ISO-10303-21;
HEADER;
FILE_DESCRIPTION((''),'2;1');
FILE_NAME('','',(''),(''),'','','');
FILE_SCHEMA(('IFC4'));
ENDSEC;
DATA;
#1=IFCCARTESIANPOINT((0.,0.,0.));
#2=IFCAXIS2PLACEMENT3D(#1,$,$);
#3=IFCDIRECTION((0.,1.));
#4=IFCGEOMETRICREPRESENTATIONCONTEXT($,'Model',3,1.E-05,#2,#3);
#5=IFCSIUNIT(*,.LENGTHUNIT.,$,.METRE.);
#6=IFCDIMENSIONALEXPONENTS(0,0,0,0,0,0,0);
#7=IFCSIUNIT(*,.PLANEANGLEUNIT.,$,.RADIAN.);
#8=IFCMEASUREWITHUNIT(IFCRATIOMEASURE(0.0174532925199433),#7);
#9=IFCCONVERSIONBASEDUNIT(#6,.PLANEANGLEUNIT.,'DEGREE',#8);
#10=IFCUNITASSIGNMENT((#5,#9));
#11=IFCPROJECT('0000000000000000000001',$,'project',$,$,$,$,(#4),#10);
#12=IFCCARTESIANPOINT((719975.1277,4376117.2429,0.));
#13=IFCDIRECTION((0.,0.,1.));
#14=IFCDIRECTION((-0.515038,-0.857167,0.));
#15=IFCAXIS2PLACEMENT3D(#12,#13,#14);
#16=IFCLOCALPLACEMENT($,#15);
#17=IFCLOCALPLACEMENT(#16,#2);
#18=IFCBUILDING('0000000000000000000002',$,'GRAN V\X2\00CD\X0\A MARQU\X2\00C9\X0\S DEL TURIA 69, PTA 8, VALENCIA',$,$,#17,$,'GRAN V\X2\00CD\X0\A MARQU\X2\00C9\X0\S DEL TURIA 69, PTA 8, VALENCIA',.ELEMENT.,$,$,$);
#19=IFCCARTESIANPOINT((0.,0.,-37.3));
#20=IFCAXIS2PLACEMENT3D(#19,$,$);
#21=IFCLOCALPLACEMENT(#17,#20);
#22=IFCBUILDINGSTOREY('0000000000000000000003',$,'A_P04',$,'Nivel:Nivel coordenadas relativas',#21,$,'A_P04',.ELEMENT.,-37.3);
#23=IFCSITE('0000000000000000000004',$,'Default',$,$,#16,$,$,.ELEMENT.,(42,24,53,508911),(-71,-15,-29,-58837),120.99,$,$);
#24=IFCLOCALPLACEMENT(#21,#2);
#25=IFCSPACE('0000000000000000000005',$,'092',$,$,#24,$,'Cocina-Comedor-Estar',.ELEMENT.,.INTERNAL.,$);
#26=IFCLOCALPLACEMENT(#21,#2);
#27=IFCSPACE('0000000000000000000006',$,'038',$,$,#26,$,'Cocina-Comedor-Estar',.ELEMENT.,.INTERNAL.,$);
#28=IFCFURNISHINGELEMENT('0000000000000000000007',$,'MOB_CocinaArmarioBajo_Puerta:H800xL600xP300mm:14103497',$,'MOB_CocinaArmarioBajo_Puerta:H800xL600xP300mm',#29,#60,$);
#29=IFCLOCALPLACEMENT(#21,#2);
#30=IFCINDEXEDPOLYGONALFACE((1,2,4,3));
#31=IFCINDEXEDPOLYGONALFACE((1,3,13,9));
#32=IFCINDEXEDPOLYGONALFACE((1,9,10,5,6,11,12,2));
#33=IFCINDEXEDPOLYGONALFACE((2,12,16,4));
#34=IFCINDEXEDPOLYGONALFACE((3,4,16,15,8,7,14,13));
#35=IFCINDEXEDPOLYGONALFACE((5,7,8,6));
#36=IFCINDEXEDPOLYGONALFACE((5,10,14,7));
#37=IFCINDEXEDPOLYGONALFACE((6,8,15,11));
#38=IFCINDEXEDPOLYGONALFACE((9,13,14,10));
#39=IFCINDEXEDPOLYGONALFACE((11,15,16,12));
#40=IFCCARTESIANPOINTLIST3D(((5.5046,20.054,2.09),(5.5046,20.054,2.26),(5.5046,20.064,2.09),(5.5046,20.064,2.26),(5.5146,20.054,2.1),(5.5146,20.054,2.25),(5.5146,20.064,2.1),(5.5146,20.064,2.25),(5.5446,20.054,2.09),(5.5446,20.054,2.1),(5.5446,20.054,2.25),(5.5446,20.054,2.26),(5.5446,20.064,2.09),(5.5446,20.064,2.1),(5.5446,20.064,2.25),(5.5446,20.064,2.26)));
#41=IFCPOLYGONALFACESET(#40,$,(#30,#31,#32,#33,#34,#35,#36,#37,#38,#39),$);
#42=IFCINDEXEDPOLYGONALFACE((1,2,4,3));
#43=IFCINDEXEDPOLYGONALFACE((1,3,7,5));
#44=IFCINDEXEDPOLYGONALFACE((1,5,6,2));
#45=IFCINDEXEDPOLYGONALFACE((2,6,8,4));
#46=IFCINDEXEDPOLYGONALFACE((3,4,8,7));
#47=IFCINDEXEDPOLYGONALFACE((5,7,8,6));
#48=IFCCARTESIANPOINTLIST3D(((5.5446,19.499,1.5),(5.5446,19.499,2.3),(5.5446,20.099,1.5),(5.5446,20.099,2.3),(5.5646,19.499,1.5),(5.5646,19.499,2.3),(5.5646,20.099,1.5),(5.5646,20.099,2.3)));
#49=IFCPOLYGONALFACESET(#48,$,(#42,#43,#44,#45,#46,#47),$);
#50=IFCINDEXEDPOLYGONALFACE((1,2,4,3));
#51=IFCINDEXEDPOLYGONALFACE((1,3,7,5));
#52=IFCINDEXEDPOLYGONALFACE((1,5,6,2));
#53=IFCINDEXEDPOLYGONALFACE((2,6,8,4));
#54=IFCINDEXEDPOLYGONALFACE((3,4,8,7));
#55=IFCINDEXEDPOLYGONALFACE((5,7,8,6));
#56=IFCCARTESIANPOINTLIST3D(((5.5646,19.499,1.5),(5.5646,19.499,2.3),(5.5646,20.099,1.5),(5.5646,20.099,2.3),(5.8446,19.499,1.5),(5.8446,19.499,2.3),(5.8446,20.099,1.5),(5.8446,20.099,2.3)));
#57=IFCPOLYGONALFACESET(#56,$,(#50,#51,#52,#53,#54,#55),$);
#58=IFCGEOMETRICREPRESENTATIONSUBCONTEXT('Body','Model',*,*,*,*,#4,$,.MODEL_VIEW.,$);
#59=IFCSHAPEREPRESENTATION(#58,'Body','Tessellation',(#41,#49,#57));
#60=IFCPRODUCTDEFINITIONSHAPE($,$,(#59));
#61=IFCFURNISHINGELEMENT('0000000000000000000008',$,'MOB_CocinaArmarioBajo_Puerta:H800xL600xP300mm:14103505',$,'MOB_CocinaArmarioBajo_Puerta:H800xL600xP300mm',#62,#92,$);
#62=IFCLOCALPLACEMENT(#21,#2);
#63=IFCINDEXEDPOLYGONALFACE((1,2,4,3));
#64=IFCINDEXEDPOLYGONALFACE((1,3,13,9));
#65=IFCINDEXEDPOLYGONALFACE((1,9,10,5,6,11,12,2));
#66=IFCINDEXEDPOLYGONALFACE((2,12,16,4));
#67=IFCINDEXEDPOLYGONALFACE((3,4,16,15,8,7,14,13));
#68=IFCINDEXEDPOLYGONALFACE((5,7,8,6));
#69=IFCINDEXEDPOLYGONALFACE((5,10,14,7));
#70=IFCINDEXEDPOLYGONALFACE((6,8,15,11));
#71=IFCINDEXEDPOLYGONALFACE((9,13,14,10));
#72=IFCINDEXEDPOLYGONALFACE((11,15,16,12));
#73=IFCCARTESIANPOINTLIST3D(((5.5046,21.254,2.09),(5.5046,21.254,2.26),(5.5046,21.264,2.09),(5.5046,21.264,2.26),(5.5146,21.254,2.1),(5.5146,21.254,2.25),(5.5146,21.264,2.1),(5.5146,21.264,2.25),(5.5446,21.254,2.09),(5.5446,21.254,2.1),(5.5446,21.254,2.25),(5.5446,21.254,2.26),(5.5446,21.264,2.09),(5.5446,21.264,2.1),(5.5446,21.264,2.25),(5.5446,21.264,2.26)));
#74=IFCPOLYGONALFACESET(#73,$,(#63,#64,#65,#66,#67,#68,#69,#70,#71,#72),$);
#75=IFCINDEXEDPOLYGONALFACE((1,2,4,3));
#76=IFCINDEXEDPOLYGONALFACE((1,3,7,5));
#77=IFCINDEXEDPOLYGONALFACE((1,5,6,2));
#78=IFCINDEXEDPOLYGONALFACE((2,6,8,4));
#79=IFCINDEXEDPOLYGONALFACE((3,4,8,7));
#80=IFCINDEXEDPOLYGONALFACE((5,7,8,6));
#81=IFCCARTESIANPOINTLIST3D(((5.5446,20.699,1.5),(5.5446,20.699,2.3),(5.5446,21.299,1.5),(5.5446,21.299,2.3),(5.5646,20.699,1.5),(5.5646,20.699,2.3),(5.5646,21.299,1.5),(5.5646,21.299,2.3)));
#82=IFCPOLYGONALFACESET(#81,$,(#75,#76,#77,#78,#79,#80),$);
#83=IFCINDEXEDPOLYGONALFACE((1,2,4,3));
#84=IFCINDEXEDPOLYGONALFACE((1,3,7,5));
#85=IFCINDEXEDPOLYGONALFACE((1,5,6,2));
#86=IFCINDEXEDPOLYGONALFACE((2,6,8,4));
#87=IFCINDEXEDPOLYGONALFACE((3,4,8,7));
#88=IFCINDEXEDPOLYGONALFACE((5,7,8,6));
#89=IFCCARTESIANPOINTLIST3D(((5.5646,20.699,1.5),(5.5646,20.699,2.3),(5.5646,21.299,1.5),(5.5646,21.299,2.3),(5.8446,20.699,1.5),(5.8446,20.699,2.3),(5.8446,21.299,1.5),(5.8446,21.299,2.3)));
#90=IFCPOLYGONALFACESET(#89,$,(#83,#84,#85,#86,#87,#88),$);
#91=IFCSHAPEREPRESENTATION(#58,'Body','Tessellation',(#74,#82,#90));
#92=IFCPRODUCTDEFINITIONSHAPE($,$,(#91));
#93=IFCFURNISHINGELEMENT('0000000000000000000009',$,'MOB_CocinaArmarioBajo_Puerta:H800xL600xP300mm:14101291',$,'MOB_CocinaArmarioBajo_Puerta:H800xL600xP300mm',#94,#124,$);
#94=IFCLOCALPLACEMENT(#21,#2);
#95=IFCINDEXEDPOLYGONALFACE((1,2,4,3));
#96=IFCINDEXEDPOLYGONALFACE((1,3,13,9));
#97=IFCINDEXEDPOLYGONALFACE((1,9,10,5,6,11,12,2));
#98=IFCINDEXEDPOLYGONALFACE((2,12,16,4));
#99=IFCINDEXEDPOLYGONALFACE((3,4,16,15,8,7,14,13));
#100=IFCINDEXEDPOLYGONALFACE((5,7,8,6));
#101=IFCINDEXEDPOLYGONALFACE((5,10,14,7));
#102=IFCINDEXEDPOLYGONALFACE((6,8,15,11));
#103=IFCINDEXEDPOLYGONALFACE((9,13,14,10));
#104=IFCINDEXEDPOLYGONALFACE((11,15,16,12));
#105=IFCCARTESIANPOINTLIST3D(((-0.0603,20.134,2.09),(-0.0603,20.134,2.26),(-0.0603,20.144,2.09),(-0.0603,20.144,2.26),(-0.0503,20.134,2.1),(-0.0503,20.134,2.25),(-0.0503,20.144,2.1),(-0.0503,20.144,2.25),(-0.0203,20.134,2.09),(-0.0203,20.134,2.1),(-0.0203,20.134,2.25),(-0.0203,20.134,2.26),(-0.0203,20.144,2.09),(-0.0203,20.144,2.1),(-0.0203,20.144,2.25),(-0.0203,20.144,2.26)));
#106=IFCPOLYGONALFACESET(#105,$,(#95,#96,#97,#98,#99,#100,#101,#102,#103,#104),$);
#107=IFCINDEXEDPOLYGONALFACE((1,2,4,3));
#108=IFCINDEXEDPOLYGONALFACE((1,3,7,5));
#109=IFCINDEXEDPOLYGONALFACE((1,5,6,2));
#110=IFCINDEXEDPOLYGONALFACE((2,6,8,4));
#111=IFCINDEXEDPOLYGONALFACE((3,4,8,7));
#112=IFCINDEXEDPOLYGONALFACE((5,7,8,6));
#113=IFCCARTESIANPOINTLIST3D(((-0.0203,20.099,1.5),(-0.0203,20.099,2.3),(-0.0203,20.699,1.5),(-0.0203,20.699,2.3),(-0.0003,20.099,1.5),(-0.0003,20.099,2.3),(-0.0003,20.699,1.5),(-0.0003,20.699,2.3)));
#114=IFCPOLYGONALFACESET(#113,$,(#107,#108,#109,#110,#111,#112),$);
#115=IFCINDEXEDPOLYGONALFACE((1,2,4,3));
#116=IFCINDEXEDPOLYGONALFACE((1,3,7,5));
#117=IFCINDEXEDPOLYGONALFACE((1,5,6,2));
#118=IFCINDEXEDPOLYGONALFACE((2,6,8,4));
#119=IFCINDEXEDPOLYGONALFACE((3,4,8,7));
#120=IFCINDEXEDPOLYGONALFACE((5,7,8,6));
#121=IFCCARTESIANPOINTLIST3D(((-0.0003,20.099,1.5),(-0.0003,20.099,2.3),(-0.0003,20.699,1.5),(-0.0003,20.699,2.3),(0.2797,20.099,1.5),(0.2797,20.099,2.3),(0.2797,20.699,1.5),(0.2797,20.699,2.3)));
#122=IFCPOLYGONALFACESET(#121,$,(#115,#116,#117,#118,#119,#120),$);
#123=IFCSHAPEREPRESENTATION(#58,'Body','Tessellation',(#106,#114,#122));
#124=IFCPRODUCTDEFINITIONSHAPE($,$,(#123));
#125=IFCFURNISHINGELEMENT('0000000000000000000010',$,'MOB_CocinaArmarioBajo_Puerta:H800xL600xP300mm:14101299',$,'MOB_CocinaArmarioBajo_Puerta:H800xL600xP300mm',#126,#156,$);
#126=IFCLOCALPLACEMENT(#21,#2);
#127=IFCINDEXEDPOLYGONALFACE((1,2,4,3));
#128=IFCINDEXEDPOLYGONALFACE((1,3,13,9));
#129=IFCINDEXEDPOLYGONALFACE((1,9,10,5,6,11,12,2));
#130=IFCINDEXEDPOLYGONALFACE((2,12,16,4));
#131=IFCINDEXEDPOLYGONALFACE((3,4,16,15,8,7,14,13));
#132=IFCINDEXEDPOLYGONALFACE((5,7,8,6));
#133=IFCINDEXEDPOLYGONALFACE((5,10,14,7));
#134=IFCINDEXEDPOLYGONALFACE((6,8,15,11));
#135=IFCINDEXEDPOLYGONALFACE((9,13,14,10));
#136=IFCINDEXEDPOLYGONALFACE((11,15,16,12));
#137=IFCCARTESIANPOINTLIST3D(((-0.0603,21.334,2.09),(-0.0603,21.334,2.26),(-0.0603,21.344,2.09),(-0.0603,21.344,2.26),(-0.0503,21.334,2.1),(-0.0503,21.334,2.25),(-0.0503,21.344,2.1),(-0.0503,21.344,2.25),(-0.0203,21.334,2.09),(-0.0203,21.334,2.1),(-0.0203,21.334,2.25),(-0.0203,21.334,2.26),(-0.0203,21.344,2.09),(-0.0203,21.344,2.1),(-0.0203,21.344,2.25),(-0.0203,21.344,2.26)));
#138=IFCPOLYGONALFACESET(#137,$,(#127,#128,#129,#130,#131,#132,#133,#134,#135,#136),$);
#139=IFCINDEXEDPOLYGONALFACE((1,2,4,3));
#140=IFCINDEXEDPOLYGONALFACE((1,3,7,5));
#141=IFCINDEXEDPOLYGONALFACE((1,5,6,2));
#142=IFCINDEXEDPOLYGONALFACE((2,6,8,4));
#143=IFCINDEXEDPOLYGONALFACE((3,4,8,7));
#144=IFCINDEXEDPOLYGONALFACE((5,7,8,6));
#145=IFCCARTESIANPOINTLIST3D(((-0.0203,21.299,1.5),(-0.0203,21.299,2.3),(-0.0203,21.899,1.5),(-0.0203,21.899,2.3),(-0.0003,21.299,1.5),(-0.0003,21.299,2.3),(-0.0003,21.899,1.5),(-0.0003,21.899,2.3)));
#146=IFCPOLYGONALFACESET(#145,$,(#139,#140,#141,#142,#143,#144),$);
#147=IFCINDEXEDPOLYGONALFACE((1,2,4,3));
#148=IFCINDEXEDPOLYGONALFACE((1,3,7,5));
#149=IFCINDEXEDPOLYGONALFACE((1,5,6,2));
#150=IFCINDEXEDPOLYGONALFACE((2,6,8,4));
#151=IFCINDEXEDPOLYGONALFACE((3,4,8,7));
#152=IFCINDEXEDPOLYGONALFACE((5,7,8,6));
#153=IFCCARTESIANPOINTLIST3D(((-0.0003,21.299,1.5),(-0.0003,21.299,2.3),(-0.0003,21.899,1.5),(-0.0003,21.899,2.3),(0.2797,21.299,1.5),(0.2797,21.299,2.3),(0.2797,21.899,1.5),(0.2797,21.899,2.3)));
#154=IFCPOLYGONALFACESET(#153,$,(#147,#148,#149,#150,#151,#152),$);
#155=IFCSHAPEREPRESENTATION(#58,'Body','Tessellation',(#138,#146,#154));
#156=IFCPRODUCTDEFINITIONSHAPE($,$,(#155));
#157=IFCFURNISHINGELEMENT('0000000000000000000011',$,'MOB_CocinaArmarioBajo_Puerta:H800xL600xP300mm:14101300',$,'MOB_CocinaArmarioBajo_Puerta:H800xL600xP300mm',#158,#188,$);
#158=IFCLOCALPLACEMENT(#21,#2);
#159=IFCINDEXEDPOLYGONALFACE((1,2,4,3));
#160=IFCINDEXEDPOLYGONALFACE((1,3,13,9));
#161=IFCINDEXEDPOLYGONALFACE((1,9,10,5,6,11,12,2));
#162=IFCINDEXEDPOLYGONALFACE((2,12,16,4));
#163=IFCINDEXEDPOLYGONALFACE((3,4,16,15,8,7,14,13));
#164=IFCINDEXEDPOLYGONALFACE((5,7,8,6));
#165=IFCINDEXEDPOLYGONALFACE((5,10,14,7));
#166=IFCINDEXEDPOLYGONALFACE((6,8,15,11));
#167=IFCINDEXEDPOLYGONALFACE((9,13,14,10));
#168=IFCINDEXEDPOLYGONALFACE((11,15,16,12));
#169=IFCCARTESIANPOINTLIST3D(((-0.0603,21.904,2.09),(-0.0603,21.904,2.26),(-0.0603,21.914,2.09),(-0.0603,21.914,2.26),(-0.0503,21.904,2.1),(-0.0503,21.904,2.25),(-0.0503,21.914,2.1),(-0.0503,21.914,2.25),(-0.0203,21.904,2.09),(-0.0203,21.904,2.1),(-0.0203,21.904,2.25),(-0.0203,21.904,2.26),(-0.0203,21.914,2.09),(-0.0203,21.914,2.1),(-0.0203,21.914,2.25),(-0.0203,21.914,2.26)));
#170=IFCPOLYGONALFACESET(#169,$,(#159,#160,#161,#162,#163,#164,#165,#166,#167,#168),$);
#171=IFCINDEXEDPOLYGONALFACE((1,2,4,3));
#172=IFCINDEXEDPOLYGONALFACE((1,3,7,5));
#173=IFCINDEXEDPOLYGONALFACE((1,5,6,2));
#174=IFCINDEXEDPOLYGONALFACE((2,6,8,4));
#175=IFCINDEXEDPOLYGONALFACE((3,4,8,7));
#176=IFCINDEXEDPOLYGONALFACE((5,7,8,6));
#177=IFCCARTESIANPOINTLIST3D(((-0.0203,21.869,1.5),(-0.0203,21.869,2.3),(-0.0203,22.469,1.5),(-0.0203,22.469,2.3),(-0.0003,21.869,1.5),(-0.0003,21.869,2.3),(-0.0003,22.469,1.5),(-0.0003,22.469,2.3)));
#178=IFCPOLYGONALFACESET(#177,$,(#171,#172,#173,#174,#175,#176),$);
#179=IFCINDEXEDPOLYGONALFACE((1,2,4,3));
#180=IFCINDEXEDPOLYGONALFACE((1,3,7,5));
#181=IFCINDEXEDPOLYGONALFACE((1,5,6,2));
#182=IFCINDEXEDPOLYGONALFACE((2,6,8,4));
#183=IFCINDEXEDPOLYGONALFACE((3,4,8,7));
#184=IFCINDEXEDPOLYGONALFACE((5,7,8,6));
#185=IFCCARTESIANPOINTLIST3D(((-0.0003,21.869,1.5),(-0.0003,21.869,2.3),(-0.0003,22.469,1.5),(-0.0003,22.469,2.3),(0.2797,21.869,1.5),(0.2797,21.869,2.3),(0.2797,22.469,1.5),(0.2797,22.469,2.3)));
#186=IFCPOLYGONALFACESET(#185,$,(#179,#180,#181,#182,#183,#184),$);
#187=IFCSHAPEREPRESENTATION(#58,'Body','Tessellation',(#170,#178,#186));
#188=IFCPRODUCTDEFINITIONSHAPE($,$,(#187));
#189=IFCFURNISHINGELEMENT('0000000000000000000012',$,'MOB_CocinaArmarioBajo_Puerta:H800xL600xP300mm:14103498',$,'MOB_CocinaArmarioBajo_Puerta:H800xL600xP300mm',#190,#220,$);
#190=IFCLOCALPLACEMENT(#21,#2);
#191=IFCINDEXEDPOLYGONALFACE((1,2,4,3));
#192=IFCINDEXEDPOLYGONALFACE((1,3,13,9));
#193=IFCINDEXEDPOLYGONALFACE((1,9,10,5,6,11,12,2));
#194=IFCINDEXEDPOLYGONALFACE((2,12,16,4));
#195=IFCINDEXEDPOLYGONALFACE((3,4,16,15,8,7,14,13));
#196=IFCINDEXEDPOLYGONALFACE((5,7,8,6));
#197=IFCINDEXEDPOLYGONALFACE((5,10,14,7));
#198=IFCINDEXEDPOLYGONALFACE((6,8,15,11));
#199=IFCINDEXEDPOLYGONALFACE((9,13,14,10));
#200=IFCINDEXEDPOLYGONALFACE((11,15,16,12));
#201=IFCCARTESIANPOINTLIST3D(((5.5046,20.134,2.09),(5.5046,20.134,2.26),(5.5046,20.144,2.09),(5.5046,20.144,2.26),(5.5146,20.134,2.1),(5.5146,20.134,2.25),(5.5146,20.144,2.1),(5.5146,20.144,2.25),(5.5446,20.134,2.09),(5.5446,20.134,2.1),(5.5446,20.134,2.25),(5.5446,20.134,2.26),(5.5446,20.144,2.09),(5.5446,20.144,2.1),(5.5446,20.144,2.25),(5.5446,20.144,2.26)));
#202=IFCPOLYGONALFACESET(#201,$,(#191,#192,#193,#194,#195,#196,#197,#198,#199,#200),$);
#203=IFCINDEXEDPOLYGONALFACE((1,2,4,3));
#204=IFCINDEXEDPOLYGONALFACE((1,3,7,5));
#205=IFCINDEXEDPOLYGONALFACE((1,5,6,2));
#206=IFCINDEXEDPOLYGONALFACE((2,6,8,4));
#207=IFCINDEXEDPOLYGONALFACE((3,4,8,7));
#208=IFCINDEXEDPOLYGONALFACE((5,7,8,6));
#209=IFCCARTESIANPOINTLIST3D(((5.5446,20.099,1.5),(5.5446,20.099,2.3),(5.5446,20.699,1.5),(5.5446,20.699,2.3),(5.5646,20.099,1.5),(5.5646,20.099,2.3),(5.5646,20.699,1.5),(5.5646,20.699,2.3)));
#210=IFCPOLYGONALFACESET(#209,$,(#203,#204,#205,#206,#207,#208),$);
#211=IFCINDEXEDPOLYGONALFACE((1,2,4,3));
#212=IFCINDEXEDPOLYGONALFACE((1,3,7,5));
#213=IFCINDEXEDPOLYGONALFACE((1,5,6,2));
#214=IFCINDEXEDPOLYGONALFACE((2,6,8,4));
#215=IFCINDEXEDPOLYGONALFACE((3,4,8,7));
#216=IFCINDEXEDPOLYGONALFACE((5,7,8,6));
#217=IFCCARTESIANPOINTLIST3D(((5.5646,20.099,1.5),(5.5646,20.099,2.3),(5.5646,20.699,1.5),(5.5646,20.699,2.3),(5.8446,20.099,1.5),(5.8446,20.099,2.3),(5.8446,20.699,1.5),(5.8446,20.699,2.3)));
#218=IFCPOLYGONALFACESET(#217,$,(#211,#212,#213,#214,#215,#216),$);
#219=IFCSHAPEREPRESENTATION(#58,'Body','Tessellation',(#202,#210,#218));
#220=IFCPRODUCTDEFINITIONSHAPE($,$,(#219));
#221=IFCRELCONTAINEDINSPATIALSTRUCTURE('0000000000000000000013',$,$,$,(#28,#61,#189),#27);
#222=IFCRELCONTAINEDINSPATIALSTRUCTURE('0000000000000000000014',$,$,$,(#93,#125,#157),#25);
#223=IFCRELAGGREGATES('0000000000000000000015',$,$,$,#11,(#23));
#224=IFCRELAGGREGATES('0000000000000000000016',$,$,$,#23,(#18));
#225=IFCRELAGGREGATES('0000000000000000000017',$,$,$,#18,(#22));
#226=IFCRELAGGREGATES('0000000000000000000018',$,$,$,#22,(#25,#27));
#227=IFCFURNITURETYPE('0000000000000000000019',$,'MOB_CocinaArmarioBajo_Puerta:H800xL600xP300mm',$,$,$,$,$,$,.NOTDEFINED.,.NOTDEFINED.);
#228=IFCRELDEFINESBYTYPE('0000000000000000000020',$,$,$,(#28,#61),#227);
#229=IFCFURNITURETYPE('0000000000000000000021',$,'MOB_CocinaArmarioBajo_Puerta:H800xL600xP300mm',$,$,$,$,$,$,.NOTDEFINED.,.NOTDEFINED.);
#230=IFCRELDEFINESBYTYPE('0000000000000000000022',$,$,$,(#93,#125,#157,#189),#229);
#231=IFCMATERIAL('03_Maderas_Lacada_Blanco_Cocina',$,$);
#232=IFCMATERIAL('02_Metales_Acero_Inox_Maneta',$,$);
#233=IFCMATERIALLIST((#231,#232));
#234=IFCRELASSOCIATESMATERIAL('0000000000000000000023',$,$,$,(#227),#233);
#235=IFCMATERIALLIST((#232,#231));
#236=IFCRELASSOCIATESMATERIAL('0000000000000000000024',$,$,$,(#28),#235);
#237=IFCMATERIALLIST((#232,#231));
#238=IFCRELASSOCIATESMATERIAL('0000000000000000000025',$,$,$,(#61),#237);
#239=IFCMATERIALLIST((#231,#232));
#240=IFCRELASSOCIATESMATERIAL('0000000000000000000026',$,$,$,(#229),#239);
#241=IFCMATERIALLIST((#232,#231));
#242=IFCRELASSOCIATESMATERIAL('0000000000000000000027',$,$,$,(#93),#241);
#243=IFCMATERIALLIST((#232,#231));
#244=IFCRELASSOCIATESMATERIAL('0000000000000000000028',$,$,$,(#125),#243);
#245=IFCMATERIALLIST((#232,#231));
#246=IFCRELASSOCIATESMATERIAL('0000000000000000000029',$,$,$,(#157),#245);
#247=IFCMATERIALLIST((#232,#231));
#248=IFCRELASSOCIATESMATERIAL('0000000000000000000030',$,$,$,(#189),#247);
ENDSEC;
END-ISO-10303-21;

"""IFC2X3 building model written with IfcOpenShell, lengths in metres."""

from ifc_helpers import new_model, entity, si_unit, converted_unit, direction, frame, frame_2d, origin, origin_2d_with_axis, place, context, subcontext, project, spatial, polyline, rectangle, outline, extrude, source, transform, mapped, material, material_list, type_object, type_shapes, element, save


model = new_model("IFC2X3")

# Units and contexts
model_context = context("Model", 3, precision=1e-05, world=origin(), true_north=direction((0.0, 1.0)))
body_context = subcontext(model_context, "Body", "Model", "MODEL_VIEW")
ifc_project = project(units=[si_unit("LENGTHUNIT", "METRE"), converted_unit("PLANEANGLEUNIT", "DEGREE", entity("IfcRatioMeasure", 0.0174532925199433), si_unit("PLANEANGLEUNIT", "RADIAN"), dimensions=[0, 0, 0, 0, 0, 0, 0])], contexts=[model_context])

# Site, building, storey
site_placement = place(None, frame((719975.1277, 4376117.2429, 0.0), z_axis=(0.0, 0.0, 1.0), x_axis=(-0.515038, -0.857167, 0.0)))
site = spatial("IfcSite", under=ifc_project, at=site_placement, Name="Default", CompositionType="ELEMENT", RefLatitude=(42, 24, 53, 508911), RefLongitude=(-71, -15, -29, -58837), RefElevation=120.99)
building_placement = place(site_placement, origin())
building = spatial("IfcBuilding", under=site, at=building_placement, Name="GRAN VÍA MARQUÉS DEL TURIA 69, PTA 8, VALENCIA", LongName="GRAN VÍA MARQUÉS DEL TURIA 69, PTA 8, VALENCIA", CompositionType="ELEMENT")
storey_placement = place(building_placement, frame((0.0, 0.0, -37.3)))
storey = spatial("IfcBuildingStorey", under=building, at=storey_placement, Name="A_P04", ObjectType="Nivel:Nivel coordenadas relativas", LongName="A_P04", CompositionType="ELEMENT", Elevation=-37.3)

# Shared definitions
space_1_placement = place(storey_placement, origin())
space_1 = spatial("IfcSpace", under=storey, at=space_1_placement, Name="092", LongName="Cocina-Comedor-Estar", CompositionType="ELEMENT", InteriorOrExteriorSpace="INTERNAL")

# Shared definitions
ifc_material_1 = material(Name="02_Metales_Acero_Inox_Maneta")
ifc_material_2 = material(Name="03_Maderas_Lacada_Blanco_Cocina")
ifc_material_list_1 = material_list([ifc_material_2, ifc_material_1])
furniture_type_1 = type_object("IfcFurnitureType", Name="MOB_CocinaArmarioBajo_Puerta:H800xL600xP300mm", material=ifc_material_list_1)
shared_shape_1 = source(origin(), body_context, "Body", "SweptSolid", [
    extrude(outline(polyline([(-0.0175, -0.075), (-0.0175, -0.085), (0.0225, -0.085), (0.0225, 0.085), (-0.0175, 0.085), (-0.0175, 0.075), (0.0125, 0.075), (0.0125, -0.075), (-0.0175, -0.075)])), frame((-0.265, -0.3175, 0.675), z_axis=(-1.0, 0.0, 0.0), x_axis=(0.0, -1.0, 0.0)), (0.0, 0.0, -1.0), 0.01),
    extrude(rectangle(XDim=0.6, YDim=0.02, at=frame_2d((0.0, 0.0), x_axis=(1.0, 0.0))), frame((0.0, -0.29, 0.0)), (0.0, 0.0, 1.0), 0.8),
    extrude(rectangle(XDim=0.28, YDim=0.6, at=origin_2d_with_axis()), frame((0.0, -0.14, 0.0), z_axis=(0.0, 0.0, 1.0), x_axis=(0.0, -1.0, 0.0)), (0.0, 0.0, 1.0), 0.8),
])
type_shapes(furniture_type_1, [shared_shape_1])

# Shared definitions
space_2_placement = place(storey_placement, origin())
space_2 = spatial("IfcSpace", under=storey, at=space_2_placement, Name="038", LongName="Cocina-Comedor-Estar", CompositionType="ELEMENT", InteriorOrExteriorSpace="INTERNAL")

# Furnishing elements
ifc_material_list_2 = material_list([ifc_material_1, ifc_material_2])
furnishing_1_placement = place(space_2_placement, frame((5.8446, 19.799, 1.5), z_axis=(0.0, 0.0, 1.0), x_axis=(0.0, -1.0, 0.0)))
element("IfcFurnishingElement", 1, at=furnishing_1_placement, inside=space_2, type_object=furniture_type_1, material=ifc_material_list_2, Name="MOB_CocinaArmarioBajo_Puerta:H800xL600xP300mm:14103497", ObjectType="MOB_CocinaArmarioBajo_Puerta:H800xL600xP300mm", context=body_context, shape_type="MappedRepresentation", body=[
    mapped(shared_shape_1, transform((0.0, 0.0, 0.0), scale=1.0)),
])
ifc_material_list_3 = material_list([ifc_material_1, ifc_material_2])
furnishing_2_placement = place(space_2_placement, frame((5.8446, 20.999, 1.5), z_axis=(0.0, 0.0, 1.0), x_axis=(0.0, -1.0, 0.0)))
element("IfcFurnishingElement", 2, at=furnishing_2_placement, inside=space_2, type_object=furniture_type_1, material=ifc_material_list_3, Name="MOB_CocinaArmarioBajo_Puerta:H800xL600xP300mm:14103505", ObjectType="MOB_CocinaArmarioBajo_Puerta:H800xL600xP300mm", context=body_context, shape_type="MappedRepresentation", body=[
    mapped(shared_shape_1, transform((0.0, 0.0, 0.0), scale=1.0)),
])
ifc_material_list_4 = material_list([ifc_material_1, ifc_material_2])
ifc_material_list_5 = material_list([ifc_material_2, ifc_material_1])
furniture_type_2 = type_object("IfcFurnitureType", Name="MOB_CocinaArmarioBajo_Puerta:H800xL600xP300mm", material=ifc_material_list_5)
shared_shape_2 = source(origin(), body_context, "Body", "SweptSolid", [
    extrude(outline(polyline([(0.075, -0.0175), (0.085, -0.0175), (0.085, 0.0225), (-0.085, 0.0225), (-0.085, -0.0175), (-0.075, -0.0175), (-0.075, 0.0125), (0.075, 0.0125), (0.075, -0.0175)])), frame((-0.265, 0.3175, 0.675), z_axis=(1.0, 0.0, 0.0), x_axis=(0.0, 0.0, -1.0)), (0.0, 0.0, 1.0), 0.01),
    extrude(rectangle(XDim=0.02, YDim=0.6, at=frame_2d((0.0, 0.0), x_axis=(1.0, 0.0))), frame((0.0, 0.29, 0.0), z_axis=(0.0, 0.0, 1.0), x_axis=(0.0, -1.0, 0.0)), (0.0, 0.0, 1.0), 0.8),
    extrude(rectangle(XDim=0.6, YDim=0.28, at=origin_2d_with_axis()), frame((0.0, 0.14, 0.0)), (0.0, 0.0, 1.0), 0.8),
])
type_shapes(furniture_type_2, [shared_shape_2])
furnishing_3_placement = place(space_1_placement, frame((0.2797, 20.399, 1.5), z_axis=(0.0, 0.0, 1.0), x_axis=(0.0, 1.0, 0.0)))
element("IfcFurnishingElement", 3, at=furnishing_3_placement, inside=space_1, type_object=furniture_type_2, material=ifc_material_list_4, Name="MOB_CocinaArmarioBajo_Puerta:H800xL600xP300mm:14101291", ObjectType="MOB_CocinaArmarioBajo_Puerta:H800xL600xP300mm", context=body_context, shape_type="MappedRepresentation", body=[
    mapped(shared_shape_2, transform((0.0, 0.0, 0.0), scale=1.0)),
])
ifc_material_list_6 = material_list([ifc_material_1, ifc_material_2])
furnishing_4_placement = place(space_1_placement, frame((0.2797, 21.599, 1.5), z_axis=(0.0, 0.0, 1.0), x_axis=(0.0, 1.0, 0.0)))
element("IfcFurnishingElement", 4, at=furnishing_4_placement, inside=space_1, type_object=furniture_type_2, material=ifc_material_list_6, Name="MOB_CocinaArmarioBajo_Puerta:H800xL600xP300mm:14101299", ObjectType="MOB_CocinaArmarioBajo_Puerta:H800xL600xP300mm", context=body_context, shape_type="MappedRepresentation", body=[
    mapped(shared_shape_2, transform((0.0, 0.0, 0.0), scale=1.0)),
])
ifc_material_list_7 = material_list([ifc_material_1, ifc_material_2])
furnishing_5_placement = place(space_1_placement, frame((0.2797, 22.169, 1.5), z_axis=(0.0, 0.0, 1.0), x_axis=(0.0, 1.0, 0.0)))
element("IfcFurnishingElement", 5, at=furnishing_5_placement, inside=space_1, type_object=furniture_type_2, material=ifc_material_list_7, Name="MOB_CocinaArmarioBajo_Puerta:H800xL600xP300mm:14101300", ObjectType="MOB_CocinaArmarioBajo_Puerta:H800xL600xP300mm", context=body_context, shape_type="MappedRepresentation", body=[
    mapped(shared_shape_2, transform((0.0, 0.0, 0.0), scale=1.0)),
])
ifc_material_list_8 = material_list([ifc_material_1, ifc_material_2])
furnishing_6_placement = place(space_2_placement, frame((5.8446, 20.399, 1.5), z_axis=(0.0, 0.0, 1.0), x_axis=(0.0, 1.0, 0.0)))
element("IfcFurnishingElement", 6, at=furnishing_6_placement, inside=space_2, type_object=furniture_type_2, material=ifc_material_list_8, Name="MOB_CocinaArmarioBajo_Puerta:H800xL600xP300mm:14103498", ObjectType="MOB_CocinaArmarioBajo_Puerta:H800xL600xP300mm", context=body_context, shape_type="MappedRepresentation", body=[
    mapped(shared_shape_2, transform((0.0, 0.0, 0.0), scale=1.0)),
])

save(model, "model.ifc")
